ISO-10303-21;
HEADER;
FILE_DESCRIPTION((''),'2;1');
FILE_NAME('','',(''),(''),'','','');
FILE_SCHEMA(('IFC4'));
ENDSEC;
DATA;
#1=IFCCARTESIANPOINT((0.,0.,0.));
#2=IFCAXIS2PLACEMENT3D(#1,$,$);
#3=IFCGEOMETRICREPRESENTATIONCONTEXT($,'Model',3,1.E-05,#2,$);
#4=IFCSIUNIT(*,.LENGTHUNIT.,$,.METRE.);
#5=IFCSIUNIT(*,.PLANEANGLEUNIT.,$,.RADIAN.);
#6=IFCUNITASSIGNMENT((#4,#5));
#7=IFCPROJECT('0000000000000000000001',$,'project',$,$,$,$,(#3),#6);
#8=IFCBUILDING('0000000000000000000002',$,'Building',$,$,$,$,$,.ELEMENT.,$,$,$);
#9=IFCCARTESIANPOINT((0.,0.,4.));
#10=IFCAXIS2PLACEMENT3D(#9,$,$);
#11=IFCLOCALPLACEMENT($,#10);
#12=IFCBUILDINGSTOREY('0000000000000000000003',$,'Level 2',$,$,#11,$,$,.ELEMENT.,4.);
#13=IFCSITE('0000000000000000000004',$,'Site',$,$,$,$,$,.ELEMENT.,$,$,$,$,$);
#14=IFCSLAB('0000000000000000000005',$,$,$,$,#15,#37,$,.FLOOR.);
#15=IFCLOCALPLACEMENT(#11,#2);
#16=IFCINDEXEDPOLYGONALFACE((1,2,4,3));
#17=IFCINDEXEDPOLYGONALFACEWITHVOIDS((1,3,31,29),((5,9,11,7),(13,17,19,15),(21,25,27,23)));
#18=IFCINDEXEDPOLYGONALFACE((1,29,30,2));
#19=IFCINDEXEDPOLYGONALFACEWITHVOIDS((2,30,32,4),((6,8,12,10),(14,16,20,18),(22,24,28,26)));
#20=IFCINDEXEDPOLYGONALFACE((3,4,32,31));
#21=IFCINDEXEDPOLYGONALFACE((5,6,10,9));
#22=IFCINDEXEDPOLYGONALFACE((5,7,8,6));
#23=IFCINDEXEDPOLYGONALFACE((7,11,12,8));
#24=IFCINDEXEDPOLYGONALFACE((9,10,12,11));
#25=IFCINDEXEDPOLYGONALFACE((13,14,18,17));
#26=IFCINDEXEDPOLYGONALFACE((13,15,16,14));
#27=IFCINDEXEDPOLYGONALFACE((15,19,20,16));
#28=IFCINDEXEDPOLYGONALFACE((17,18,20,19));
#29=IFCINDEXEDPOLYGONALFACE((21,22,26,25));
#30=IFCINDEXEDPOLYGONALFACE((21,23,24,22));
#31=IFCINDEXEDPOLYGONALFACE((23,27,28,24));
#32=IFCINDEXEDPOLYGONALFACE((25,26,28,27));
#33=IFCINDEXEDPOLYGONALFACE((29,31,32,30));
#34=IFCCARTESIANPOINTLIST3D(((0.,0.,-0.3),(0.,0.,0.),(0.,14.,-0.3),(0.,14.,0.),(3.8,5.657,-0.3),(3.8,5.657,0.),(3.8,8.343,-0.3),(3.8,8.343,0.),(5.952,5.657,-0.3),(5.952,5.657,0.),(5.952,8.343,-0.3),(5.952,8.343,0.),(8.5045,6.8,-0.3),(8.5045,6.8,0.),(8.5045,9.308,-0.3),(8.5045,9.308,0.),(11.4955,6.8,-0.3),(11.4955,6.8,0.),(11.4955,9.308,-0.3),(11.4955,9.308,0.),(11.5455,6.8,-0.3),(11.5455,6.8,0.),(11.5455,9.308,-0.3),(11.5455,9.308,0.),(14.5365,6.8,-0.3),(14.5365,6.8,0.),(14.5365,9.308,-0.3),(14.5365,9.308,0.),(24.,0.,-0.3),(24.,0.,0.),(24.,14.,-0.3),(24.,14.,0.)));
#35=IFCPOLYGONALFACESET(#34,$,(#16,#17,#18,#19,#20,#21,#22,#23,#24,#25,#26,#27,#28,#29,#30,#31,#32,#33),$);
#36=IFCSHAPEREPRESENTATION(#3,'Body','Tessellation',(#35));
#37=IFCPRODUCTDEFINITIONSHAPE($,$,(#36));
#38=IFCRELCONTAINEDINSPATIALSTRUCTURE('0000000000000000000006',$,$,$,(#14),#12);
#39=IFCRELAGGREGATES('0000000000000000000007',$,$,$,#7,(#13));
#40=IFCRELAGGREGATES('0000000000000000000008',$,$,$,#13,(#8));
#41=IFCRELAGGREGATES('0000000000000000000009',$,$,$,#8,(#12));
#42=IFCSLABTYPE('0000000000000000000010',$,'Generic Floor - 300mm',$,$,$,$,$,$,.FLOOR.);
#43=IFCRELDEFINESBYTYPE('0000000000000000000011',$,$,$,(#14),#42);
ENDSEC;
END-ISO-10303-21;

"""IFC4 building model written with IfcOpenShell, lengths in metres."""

from ifc_helpers import new_model, si_unit, frame, origin, place, context, project, spatial, polyline, outline, extrude, type_object, element, save


model = new_model("IFC4")

# Units and contexts
model_context = context("Model", 3, precision=1e-05, world=origin())
ifc_project = project(units=[si_unit("LENGTHUNIT", "METRE"), si_unit("PLANEANGLEUNIT", "RADIAN")], contexts=[model_context])

# Site, building, storey
site = spatial("IfcSite", under=ifc_project, Name="Site", CompositionType="ELEMENT")
building = spatial("IfcBuilding", under=site, Name="Building", CompositionType="ELEMENT")
storey_placement = place(None, frame((0.0, 0.0, 4.0)))
storey = spatial("IfcBuildingStorey", under=building, at=storey_placement, Name="Level 2", CompositionType="ELEMENT", Elevation=4.0)

# Slab, openings
slab_type = type_object("IfcSlabType", Name="Generic Floor - 300mm", PredefinedType="FLOOR")
slab_placement = place(None, frame((0.0, 0.0, 4.0)))
slab = element("IfcSlab", 1, at=slab_placement, inside=storey, type_object=slab_type, PredefinedType="FLOOR", context=model_context, shape_type="SweptSolid", body=[
    extrude(outline(polyline([(0.0, 0.0), (24.0, 0.0), (24.0, 14.0), (0.0, 14.0), (0.0, 0.0)])), origin(), (0.0, 0.0, -1.0), 0.3),
])
opening_1_placement = place(None, frame((0.0, 0.0, 4.001)))
element("IfcOpeningElement", 2, at=opening_1_placement, cuts=slab, PredefinedType="OPENING", context=model_context, shape_type="SweptSolid", body=[
    extrude(outline(polyline([(8.5045, 6.8), (11.4955, 6.8), (11.4955, 9.308), (8.5045, 9.308), (8.5045, 6.8)])), origin(), (0.0, 0.0, -1.0), 0.302),
])
opening_2_placement = place(None, frame((0.0, 0.0, 4.001)))
element("IfcOpeningElement", 3, at=opening_2_placement, cuts=slab, PredefinedType="OPENING", context=model_context, shape_type="SweptSolid", body=[
    extrude(outline(polyline([(11.5455, 6.8), (14.5365, 6.8), (14.5365, 9.308), (11.5455, 9.308), (11.5455, 6.8)])), origin(), (0.0, 0.0, -1.0), 0.302),
])
opening_3_placement = place(None, frame((0.0, 0.0, 4.001)))
element("IfcOpeningElement", 4, at=opening_3_placement, cuts=slab, PredefinedType="OPENING", context=model_context, shape_type="SweptSolid", body=[
    extrude(outline(polyline([(3.8, 8.343), (3.8, 5.657), (5.952, 5.657), (5.952, 8.343), (3.8, 8.343)])), origin(), (0.0, 0.0, -1.0), 0.302),
])

save(model, "model.ifc")
